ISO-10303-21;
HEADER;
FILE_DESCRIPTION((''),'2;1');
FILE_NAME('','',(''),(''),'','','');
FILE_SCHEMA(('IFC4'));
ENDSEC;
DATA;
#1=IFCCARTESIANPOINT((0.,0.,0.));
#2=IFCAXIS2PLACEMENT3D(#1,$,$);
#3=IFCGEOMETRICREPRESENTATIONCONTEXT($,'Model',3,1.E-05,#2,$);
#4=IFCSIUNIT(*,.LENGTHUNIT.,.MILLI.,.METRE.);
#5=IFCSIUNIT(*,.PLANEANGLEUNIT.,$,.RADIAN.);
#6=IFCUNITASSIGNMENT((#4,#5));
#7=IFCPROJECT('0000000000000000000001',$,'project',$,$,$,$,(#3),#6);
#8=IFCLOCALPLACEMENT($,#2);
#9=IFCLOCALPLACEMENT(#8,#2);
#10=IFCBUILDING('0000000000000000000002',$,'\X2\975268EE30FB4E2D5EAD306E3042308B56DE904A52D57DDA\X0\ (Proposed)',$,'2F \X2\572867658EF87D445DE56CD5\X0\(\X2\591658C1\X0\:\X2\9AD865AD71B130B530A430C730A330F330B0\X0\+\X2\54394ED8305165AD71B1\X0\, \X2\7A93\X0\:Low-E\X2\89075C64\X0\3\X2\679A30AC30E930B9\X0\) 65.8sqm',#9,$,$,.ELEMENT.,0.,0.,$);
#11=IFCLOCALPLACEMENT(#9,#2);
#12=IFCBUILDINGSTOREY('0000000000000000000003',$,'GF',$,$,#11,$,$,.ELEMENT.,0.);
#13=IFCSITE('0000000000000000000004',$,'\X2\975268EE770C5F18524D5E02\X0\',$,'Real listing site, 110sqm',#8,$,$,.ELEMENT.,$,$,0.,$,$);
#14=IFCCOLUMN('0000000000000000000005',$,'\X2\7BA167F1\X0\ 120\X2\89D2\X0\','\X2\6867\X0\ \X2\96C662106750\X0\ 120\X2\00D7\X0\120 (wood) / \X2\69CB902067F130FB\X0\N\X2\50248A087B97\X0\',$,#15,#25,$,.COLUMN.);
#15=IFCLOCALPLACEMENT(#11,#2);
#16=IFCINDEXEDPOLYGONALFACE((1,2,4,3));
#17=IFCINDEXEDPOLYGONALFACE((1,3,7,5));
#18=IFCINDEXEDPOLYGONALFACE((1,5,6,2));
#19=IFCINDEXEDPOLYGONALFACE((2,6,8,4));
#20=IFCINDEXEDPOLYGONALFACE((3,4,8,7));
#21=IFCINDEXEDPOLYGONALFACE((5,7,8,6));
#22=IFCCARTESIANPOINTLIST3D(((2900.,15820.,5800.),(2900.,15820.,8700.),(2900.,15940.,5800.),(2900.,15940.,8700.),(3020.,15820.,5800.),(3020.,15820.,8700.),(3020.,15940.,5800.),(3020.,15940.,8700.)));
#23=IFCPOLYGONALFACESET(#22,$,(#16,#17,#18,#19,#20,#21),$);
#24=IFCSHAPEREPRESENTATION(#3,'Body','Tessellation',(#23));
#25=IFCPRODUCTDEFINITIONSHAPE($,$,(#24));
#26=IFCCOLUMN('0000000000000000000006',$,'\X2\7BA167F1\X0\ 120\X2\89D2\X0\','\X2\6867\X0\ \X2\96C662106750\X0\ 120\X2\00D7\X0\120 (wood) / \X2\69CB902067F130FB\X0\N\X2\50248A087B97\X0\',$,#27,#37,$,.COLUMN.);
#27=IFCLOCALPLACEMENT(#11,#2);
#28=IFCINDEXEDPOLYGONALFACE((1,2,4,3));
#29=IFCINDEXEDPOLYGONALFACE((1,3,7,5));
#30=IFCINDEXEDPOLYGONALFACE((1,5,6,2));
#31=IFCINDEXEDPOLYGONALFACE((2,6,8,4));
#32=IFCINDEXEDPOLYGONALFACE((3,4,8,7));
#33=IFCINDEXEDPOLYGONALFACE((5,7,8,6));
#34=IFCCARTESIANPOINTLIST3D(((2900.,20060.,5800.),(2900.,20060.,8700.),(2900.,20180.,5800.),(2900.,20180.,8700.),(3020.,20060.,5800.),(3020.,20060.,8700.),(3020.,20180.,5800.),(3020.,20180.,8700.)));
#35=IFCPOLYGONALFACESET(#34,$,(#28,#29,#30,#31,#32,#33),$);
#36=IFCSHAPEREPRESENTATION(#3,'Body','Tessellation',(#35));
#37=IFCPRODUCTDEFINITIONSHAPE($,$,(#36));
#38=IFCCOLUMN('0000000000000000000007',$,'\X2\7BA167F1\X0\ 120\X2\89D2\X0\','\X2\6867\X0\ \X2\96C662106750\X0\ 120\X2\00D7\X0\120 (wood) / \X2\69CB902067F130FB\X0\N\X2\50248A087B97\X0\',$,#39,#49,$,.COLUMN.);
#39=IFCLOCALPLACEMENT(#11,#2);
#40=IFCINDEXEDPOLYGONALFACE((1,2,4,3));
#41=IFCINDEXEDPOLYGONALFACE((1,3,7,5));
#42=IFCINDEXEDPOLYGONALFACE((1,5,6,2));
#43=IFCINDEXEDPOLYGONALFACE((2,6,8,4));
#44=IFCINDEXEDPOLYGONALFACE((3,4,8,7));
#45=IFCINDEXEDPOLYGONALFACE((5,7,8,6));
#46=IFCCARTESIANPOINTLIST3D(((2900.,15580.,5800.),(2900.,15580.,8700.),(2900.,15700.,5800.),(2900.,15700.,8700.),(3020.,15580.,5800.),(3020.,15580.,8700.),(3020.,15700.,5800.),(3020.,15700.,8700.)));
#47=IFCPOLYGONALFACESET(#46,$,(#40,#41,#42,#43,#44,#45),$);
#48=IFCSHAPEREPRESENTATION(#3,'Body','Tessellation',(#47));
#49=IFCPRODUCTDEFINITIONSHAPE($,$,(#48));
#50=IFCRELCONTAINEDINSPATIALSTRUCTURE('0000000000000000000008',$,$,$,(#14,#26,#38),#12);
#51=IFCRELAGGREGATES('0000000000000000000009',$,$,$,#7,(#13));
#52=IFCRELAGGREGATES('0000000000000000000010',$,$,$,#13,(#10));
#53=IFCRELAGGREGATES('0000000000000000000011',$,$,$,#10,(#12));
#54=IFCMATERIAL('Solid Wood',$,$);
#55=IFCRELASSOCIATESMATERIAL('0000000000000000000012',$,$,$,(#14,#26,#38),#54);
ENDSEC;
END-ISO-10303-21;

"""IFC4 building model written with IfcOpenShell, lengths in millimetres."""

from ifc_helpers import new_model, si_unit, frame, frame_2d, origin, place, context, project, spatial, rectangle, extrude, material, element, save


model = new_model("IFC4")

# Units and contexts
model_context = context("Model", 3, precision=1e-05, world=origin())
ifc_project = project(units=[si_unit("LENGTHUNIT", "METRE", prefix="MILLI"), si_unit("PLANEANGLEUNIT", "RADIAN")], contexts=[model_context])

# Site, building, storey
site_placement = place(None, origin())
site = spatial("IfcSite", under=ifc_project, at=site_placement, Name="青森県弘前市", ObjectType="Real listing site, 110sqm", CompositionType="ELEMENT", RefElevation=0.0)
building_placement = place(site_placement, origin())
building = spatial("IfcBuilding", under=site, at=building_placement, Name="青森・中庭のある回遊動線 (Proposed)", ObjectType="2F 在来軸組工法(外壁:高断熱サイディング+吹付け断熱, 窓:Low-E複層3枚ガラス) 65.8sqm", CompositionType="ELEMENT", ElevationOfRefHeight=0.0, ElevationOfTerrain=0.0)
storey_placement = place(building_placement, origin())
storey = spatial("IfcBuildingStorey", under=building, at=storey_placement, Name="GF", CompositionType="ELEMENT", Elevation=0.0)

# Columns
ifc_material_1 = material(Name="Solid Wood")
column_1_placement = place(storey_placement, frame((1450.0, 7910.0, 2900.0)))
element("IfcColumn", 1, at=column_1_placement, inside=storey, material=ifc_material_1, Name="管柱 120角", Description="桧 集成材 120×120 (wood) / 構造柱・N値計算", PredefinedType="COLUMN", context=model_context, shape_type="SweptSolid", body=[
    extrude(rectangle(XDim=120.0, YDim=120.0, at=frame_2d((60.0, 60.0))), frame((1450.0, 7910.0, 2900.0)), (0.0, 0.0, 1.0), 2900.0),
])
column_2_placement = place(storey_placement, frame((1450.0, 10030.0, 2900.0)))
element("IfcColumn", 2, at=column_2_placement, inside=storey, material=ifc_material_1, Name="管柱 120角", Description="桧 集成材 120×120 (wood) / 構造柱・N値計算", PredefinedType="COLUMN", context=model_context, shape_type="SweptSolid", body=[
    extrude(rectangle(XDim=120.0, YDim=120.0, at=frame_2d((60.0, 60.0))), frame((1450.0, 10030.0, 2900.0)), (0.0, 0.0, 1.0), 2900.0),
])
column_3_placement = place(storey_placement, frame((1450.0, 7790.0, 2900.0)))
element("IfcColumn", 3, at=column_3_placement, inside=storey, material=ifc_material_1, Name="管柱 120角", Description="桧 集成材 120×120 (wood) / 構造柱・N値計算", PredefinedType="COLUMN", context=model_context, shape_type="SweptSolid", body=[
    extrude(rectangle(XDim=120.0, YDim=120.0, at=frame_2d((60.0, 60.0))), frame((1450.0, 7790.0, 2900.0)), (0.0, 0.0, 1.0), 2900.0),
])

save(model, "model.ifc")
